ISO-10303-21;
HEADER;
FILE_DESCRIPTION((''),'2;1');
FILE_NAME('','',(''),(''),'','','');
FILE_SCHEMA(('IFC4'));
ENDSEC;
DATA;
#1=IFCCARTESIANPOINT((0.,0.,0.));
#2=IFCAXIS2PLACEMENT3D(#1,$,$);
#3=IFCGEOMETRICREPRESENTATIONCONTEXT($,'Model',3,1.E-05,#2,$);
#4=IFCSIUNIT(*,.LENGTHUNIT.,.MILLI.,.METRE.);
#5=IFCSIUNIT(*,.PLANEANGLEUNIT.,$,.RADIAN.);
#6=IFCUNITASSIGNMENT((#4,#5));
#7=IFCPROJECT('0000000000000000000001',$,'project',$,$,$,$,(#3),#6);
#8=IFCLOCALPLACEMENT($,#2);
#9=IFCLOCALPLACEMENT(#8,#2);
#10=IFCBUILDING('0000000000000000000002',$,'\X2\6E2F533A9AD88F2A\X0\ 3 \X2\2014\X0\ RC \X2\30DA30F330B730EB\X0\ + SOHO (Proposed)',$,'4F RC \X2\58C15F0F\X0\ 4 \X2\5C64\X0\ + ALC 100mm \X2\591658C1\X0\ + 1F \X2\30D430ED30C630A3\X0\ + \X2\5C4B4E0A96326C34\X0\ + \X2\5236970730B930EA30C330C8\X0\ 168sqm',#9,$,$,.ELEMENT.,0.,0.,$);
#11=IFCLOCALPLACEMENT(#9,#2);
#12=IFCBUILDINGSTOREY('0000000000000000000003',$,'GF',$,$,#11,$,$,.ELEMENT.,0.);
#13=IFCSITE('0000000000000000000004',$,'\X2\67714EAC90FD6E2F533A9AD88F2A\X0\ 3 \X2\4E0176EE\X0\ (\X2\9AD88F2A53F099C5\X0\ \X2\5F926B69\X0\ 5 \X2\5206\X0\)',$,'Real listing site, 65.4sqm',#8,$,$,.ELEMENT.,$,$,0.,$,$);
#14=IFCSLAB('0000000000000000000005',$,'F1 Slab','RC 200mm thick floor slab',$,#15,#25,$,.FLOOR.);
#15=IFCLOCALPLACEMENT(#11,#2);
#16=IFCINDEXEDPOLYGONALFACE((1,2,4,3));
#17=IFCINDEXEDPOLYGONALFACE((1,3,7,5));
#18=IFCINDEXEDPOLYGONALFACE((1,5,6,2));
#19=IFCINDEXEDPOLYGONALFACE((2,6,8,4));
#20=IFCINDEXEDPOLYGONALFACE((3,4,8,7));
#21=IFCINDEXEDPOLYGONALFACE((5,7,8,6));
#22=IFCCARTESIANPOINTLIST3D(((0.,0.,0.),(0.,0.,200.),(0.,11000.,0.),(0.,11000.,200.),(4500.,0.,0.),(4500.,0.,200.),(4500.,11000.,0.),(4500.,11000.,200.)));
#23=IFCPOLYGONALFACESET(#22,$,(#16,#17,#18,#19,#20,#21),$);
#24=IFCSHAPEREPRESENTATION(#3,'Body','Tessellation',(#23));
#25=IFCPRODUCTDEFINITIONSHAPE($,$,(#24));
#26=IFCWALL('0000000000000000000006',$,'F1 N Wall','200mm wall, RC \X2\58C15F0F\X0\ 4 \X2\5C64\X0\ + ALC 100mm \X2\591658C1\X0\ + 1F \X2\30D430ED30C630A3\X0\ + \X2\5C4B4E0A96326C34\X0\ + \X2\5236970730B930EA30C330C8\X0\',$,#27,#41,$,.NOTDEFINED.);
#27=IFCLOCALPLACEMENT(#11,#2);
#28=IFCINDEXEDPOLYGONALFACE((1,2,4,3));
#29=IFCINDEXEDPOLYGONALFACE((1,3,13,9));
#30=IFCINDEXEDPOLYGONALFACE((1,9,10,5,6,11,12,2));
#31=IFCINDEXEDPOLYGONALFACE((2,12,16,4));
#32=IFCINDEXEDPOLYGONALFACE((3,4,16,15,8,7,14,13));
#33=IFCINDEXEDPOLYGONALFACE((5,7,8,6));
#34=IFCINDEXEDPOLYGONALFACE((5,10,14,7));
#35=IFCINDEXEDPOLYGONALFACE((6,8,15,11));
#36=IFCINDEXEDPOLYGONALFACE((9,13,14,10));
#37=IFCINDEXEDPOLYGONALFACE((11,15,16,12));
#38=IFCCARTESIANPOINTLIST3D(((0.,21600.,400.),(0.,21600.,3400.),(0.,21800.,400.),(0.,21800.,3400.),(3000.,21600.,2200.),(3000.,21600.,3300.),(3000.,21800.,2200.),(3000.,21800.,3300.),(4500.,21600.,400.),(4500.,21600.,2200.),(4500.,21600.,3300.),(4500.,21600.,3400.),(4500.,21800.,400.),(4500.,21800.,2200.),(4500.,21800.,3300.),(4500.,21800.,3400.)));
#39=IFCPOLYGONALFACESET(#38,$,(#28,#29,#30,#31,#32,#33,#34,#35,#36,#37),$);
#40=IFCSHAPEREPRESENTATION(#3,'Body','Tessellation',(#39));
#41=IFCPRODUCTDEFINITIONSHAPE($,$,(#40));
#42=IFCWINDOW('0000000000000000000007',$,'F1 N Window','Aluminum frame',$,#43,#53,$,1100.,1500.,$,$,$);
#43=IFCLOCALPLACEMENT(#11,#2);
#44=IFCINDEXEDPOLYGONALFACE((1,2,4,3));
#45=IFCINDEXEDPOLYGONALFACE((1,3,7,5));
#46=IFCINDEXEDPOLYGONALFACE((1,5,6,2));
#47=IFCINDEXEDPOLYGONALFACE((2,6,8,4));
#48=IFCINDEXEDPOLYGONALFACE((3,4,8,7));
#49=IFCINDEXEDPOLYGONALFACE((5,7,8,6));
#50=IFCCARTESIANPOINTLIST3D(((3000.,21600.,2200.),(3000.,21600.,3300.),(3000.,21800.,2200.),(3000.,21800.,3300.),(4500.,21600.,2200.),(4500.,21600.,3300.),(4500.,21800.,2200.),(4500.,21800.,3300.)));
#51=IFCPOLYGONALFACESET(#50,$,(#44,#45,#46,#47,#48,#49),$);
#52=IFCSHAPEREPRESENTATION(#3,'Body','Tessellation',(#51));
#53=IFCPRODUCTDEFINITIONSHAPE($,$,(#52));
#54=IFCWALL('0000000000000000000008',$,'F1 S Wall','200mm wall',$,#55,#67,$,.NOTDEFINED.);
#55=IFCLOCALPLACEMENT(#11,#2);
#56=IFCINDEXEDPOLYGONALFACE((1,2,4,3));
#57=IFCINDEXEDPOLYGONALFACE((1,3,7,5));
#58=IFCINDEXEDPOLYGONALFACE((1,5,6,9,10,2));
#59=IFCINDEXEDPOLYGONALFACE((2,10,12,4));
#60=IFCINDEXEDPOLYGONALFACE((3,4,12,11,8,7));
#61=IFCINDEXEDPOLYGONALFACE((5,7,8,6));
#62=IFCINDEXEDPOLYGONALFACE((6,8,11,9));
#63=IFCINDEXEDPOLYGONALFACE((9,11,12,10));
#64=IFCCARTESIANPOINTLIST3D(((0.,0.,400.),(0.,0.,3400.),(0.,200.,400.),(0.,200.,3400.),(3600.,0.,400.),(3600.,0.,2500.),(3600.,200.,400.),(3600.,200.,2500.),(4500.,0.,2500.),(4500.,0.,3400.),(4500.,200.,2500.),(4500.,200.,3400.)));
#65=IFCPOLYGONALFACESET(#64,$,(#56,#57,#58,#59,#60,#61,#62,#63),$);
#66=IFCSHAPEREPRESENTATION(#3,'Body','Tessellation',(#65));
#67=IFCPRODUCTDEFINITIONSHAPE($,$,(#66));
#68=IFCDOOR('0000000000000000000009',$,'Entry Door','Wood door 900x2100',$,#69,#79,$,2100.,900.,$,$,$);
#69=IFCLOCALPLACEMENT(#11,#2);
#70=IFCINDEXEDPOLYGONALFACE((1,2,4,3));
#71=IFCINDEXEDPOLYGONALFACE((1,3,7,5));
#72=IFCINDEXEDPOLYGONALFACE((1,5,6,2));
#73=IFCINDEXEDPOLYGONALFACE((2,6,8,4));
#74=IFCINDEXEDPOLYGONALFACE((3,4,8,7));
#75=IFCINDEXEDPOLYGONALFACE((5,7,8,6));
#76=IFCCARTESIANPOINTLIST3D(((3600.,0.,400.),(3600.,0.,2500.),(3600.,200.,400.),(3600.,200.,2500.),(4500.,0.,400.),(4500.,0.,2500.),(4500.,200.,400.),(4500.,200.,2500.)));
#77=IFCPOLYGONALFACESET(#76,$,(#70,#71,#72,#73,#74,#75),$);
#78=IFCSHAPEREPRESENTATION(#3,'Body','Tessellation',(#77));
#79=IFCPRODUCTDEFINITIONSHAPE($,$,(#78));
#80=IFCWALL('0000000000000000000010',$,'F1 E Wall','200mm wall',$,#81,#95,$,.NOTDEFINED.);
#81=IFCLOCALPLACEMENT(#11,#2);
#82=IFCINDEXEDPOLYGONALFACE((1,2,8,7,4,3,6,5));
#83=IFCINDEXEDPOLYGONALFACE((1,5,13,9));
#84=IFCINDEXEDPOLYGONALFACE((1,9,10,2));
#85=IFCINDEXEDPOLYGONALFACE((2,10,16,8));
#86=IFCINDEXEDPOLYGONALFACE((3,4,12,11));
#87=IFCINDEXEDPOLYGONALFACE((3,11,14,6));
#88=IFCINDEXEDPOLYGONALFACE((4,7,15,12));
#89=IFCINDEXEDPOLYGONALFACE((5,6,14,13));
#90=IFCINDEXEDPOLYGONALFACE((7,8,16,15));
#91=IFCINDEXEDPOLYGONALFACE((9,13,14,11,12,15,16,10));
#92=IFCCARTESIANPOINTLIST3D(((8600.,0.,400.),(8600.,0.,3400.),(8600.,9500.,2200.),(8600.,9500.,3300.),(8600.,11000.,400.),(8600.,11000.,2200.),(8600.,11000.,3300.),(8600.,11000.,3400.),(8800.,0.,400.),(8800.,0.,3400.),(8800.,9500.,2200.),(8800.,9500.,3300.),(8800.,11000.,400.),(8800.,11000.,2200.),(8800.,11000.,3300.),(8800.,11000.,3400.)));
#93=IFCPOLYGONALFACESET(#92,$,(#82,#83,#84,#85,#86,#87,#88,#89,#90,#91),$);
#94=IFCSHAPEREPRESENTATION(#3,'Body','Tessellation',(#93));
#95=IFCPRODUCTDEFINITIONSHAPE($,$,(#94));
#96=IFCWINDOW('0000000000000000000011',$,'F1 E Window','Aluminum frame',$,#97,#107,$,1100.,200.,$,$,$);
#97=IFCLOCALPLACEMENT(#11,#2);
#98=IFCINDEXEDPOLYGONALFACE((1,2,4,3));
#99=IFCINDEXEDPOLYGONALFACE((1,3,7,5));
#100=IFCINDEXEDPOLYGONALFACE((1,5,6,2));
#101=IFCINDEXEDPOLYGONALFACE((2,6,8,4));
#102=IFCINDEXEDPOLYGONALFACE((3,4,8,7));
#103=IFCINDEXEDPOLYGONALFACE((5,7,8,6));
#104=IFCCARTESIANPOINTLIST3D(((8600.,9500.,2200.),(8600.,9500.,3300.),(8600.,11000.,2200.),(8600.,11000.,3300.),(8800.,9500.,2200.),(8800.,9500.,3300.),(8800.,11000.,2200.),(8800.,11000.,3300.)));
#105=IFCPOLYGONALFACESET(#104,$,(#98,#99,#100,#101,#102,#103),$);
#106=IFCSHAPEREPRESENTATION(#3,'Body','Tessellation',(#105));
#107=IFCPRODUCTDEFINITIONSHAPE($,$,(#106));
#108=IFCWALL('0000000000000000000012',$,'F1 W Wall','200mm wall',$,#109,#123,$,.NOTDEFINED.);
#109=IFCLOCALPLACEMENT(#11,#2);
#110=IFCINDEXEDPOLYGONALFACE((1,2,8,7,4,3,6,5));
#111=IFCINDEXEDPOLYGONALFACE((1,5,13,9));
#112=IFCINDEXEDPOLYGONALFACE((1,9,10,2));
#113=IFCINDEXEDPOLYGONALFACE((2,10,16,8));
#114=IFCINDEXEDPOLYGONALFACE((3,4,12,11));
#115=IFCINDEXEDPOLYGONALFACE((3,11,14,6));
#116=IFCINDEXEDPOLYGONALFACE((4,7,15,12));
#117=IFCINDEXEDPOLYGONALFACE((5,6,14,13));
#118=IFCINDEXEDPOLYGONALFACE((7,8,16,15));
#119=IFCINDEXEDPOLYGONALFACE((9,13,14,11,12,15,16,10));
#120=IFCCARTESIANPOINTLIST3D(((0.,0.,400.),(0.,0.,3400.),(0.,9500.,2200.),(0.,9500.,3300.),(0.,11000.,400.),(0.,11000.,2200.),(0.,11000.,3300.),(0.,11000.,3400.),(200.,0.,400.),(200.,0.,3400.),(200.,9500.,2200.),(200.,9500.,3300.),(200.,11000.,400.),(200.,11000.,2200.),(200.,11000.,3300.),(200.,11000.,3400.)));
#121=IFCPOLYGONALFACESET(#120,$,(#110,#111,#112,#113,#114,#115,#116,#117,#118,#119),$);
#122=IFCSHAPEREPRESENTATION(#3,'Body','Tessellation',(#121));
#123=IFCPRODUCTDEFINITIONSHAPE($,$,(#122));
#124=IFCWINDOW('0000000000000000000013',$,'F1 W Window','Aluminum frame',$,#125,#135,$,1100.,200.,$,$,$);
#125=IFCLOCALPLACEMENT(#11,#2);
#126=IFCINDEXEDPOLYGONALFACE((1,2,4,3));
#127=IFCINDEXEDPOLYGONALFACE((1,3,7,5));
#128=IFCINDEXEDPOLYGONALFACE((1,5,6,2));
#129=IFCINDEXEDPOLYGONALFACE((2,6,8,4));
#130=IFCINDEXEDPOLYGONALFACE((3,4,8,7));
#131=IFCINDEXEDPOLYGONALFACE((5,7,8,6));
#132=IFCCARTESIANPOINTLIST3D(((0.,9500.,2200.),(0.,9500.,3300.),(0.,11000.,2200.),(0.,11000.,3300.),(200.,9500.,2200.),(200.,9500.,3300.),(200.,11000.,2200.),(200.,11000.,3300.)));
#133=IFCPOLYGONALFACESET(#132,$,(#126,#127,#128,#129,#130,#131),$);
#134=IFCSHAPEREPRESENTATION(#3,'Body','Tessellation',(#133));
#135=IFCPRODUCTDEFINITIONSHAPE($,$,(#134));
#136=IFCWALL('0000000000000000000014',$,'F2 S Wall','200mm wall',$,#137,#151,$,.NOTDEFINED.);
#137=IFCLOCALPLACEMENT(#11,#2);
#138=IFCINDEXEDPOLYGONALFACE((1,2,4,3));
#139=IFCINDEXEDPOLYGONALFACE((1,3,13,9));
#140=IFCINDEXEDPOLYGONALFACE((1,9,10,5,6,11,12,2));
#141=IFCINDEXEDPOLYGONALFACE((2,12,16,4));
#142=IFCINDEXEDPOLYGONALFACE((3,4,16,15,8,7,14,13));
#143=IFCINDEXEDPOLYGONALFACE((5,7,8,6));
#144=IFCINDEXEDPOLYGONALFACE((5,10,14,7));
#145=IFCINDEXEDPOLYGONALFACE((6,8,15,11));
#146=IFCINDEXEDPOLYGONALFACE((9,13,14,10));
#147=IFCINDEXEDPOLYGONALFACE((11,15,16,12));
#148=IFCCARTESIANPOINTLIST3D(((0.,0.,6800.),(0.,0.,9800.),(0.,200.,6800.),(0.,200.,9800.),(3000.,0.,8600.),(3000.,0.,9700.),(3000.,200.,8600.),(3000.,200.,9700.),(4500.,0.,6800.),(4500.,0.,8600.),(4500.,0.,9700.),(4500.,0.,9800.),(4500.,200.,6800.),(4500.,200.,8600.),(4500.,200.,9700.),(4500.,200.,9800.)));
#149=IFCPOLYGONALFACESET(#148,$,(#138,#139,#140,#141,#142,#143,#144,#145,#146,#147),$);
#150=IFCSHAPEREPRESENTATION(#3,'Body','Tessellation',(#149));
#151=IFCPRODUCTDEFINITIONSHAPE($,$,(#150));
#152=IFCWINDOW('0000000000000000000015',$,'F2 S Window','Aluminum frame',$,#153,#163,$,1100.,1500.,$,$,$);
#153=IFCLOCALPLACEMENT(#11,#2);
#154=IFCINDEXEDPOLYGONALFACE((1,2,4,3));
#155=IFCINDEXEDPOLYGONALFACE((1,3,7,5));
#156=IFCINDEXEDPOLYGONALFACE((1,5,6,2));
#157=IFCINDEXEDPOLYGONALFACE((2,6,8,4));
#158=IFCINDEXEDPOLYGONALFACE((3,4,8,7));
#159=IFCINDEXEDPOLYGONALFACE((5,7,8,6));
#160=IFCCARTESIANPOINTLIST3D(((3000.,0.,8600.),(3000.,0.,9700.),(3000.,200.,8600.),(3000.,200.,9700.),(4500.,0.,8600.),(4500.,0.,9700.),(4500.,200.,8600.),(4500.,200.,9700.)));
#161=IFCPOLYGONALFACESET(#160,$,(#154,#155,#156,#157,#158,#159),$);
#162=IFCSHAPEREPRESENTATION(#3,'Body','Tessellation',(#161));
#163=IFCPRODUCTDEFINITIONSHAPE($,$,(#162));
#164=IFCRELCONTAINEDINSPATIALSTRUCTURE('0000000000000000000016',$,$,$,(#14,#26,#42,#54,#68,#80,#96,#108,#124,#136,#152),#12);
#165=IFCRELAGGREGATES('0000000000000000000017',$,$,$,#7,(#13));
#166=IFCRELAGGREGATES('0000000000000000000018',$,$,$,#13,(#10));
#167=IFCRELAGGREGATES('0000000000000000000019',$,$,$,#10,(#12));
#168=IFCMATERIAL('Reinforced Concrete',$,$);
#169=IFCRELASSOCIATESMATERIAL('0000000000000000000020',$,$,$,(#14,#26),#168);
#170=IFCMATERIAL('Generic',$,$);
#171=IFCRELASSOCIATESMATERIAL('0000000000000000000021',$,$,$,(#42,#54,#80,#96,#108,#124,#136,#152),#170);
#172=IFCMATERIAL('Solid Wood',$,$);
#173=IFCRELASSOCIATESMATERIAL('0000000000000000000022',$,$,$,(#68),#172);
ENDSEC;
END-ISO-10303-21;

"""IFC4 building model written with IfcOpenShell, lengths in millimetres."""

from ifc_helpers import new_model, si_unit, frame, frame_2d, origin, place, context, project, spatial, rectangle, extrude, material, element, fill, save


model = new_model("IFC4")

# Units and contexts
model_context = context("Model", 3, precision=1e-05, world=origin())
ifc_project = project(units=[si_unit("LENGTHUNIT", "METRE", prefix="MILLI"), si_unit("PLANEANGLEUNIT", "RADIAN")], contexts=[model_context])

# Site, building, storey
site_placement = place(None, origin())
site = spatial("IfcSite", under=ifc_project, at=site_placement, Name="東京都港区高輪 3 丁目 (高輪台駅 徒歩 5 分)", ObjectType="Real listing site, 65.4sqm", CompositionType="ELEMENT", RefElevation=0.0)
building_placement = place(site_placement, origin())
building = spatial("IfcBuilding", under=site, at=building_placement, Name="港区高輪 3 — RC ペンシル + SOHO (Proposed)", ObjectType="4F RC 壁式 4 層 + ALC 100mm 外壁 + 1F ピロティ + 屋上防水 + 制震スリット 168sqm", CompositionType="ELEMENT", ElevationOfRefHeight=0.0, ElevationOfTerrain=0.0)
storey_placement = place(building_placement, origin())
storey = spatial("IfcBuildingStorey", under=building, at=storey_placement, Name="GF", CompositionType="ELEMENT", Elevation=0.0)

# Slab
ifc_material_1 = material(Name="Reinforced Concrete")
slab_1_placement = place(storey_placement, origin())
element("IfcSlab", 1, at=slab_1_placement, inside=storey, material=ifc_material_1, Name="F1 Slab", Description="RC 200mm thick floor slab", PredefinedType="FLOOR", context=model_context, shape_type="SweptSolid", body=[
    extrude(rectangle(XDim=4500.0, YDim=11000.0, at=frame_2d((2250.0, 5500.0))), origin(), (0.0, 0.0, 1.0), 200.0),
])

# Wall, opening, window
wall_1_placement = place(storey_placement, frame((0.0, 10800.0, 200.0)))
wall_1 = element("IfcWall", 2, at=wall_1_placement, inside=storey, material=ifc_material_1, Name="F1 N Wall", Description="200mm wall, RC 壁式 4 層 + ALC 100mm 外壁 + 1F ピロティ + 屋上防水 + 制震スリット", PredefinedType="NOTDEFINED", context=model_context, shape_type="SweptSolid", body=[
    extrude(rectangle(XDim=4500.0, YDim=200.0, at=frame_2d((2250.0, 100.0))), frame((0.0, 10800.0, 200.0)), (0.0, 0.0, 1.0), 3000.0),
])
opening_1_placement = place(storey_placement, frame((1500.0, 10800.0, 1100.0)))
opening_1 = element("IfcOpeningElement", 3, at=opening_1_placement, cuts=wall_1, PredefinedType="NOTDEFINED", context=model_context, shape_type="SweptSolid", body=[
    extrude(rectangle(XDim=1500.0, YDim=200.0, at=frame_2d((750.0, 100.0))), frame((1500.0, 10800.0, 1100.0)), (0.0, 0.0, 1.0), 1100.0),
])
ifc_material_2 = material(Name="Generic")
window_1_placement = place(storey_placement, frame((1500.0, 10800.0, 1100.0)))
window_1 = element("IfcWindow", 4, at=window_1_placement, inside=storey, material=ifc_material_2, Name="F1 N Window", Description="Aluminum frame", OverallHeight=1100.0, OverallWidth=1500.0, context=model_context, shape_type="SweptSolid", body=[
    extrude(rectangle(XDim=1500.0, YDim=200.0, at=frame_2d((750.0, 100.0))), frame((1500.0, 10800.0, 1100.0)), (0.0, 0.0, 1.0), 1100.0),
])
fill(opening_1, window_1)

# Wall, opening, door
wall_2_placement = place(storey_placement, frame((0.0, 0.0, 200.0)))
wall_2 = element("IfcWall", 5, at=wall_2_placement, inside=storey, material=ifc_material_2, Name="F1 S Wall", Description="200mm wall", PredefinedType="NOTDEFINED", context=model_context, shape_type="SweptSolid", body=[
    extrude(rectangle(XDim=4500.0, YDim=200.0, at=frame_2d((2250.0, 100.0))), frame((0.0, 0.0, 200.0)), (0.0, 0.0, 1.0), 3000.0),
])
opening_2_placement = place(storey_placement, frame((1800.0, 0.0, 200.0)))
opening_2 = element("IfcOpeningElement", 6, at=opening_2_placement, cuts=wall_2, PredefinedType="NOTDEFINED", context=model_context, shape_type="SweptSolid", body=[
    extrude(rectangle(XDim=900.0, YDim=200.0, at=frame_2d((450.0, 100.0))), frame((1800.0, 0.0, 200.0)), (0.0, 0.0, 1.0), 2100.0),
])
ifc_material_3 = material(Name="Solid Wood")
door_placement = place(storey_placement, frame((1800.0, 0.0, 200.0)))
door = element("IfcDoor", 7, at=door_placement, inside=storey, material=ifc_material_3, Name="Entry Door", Description="Wood door 900x2100", OverallHeight=2100.0, OverallWidth=900.0, context=model_context, shape_type="SweptSolid", body=[
    extrude(rectangle(XDim=900.0, YDim=200.0, at=frame_2d((450.0, 100.0))), frame((1800.0, 0.0, 200.0)), (0.0, 0.0, 1.0), 2100.0),
])
fill(opening_2, door)

# Walls, openings, windows
wall_3_placement = place(storey_placement, frame((4300.0, 0.0, 200.0)))
wall_3 = element("IfcWall", 8, at=wall_3_placement, inside=storey, material=ifc_material_2, Name="F1 E Wall", Description="200mm wall", PredefinedType="NOTDEFINED", context=model_context, shape_type="SweptSolid", body=[
    extrude(rectangle(XDim=200.0, YDim=11000.0, at=frame_2d((100.0, 5500.0))), frame((4300.0, 0.0, 200.0)), (0.0, 0.0, 1.0), 3000.0),
])
opening_3_placement = place(storey_placement, frame((4300.0, 4750.0, 1100.0)))
opening_3 = element("IfcOpeningElement", 9, at=opening_3_placement, cuts=wall_3, PredefinedType="NOTDEFINED", context=model_context, shape_type="SweptSolid", body=[
    extrude(rectangle(XDim=200.0, YDim=1500.0, at=frame_2d((100.0, 750.0))), frame((4300.0, 4750.0, 1100.0)), (0.0, 0.0, 1.0), 1100.0),
])
window_2_placement = place(storey_placement, frame((4300.0, 4750.0, 1100.0)))
window_2 = element("IfcWindow", 10, at=window_2_placement, inside=storey, material=ifc_material_2, Name="F1 E Window", Description="Aluminum frame", OverallHeight=1100.0, OverallWidth=200.0, context=model_context, shape_type="SweptSolid", body=[
    extrude(rectangle(XDim=200.0, YDim=1500.0, at=frame_2d((100.0, 750.0))), frame((4300.0, 4750.0, 1100.0)), (0.0, 0.0, 1.0), 1100.0),
])
fill(opening_3, window_2)
wall_4_placement = place(storey_placement, frame((0.0, 0.0, 200.0)))
wall_4 = element("IfcWall", 11, at=wall_4_placement, inside=storey, material=ifc_material_2, Name="F1 W Wall", Description="200mm wall", PredefinedType="NOTDEFINED", context=model_context, shape_type="SweptSolid", body=[
    extrude(rectangle(XDim=200.0, YDim=11000.0, at=frame_2d((100.0, 5500.0))), frame((0.0, 0.0, 200.0)), (0.0, 0.0, 1.0), 3000.0),
])
opening_4_placement = place(storey_placement, frame((0.0, 4750.0, 1100.0)))
opening_4 = element("IfcOpeningElement", 12, at=opening_4_placement, cuts=wall_4, PredefinedType="NOTDEFINED", context=model_context, shape_type="SweptSolid", body=[
    extrude(rectangle(XDim=200.0, YDim=1500.0, at=frame_2d((100.0, 750.0))), frame((0.0, 4750.0, 1100.0)), (0.0, 0.0, 1.0), 1100.0),
])
window_3_placement = place(storey_placement, frame((0.0, 4750.0, 1100.0)))
window_3 = element("IfcWindow", 13, at=window_3_placement, inside=storey, material=ifc_material_2, Name="F1 W Window", Description="Aluminum frame", OverallHeight=1100.0, OverallWidth=200.0, context=model_context, shape_type="SweptSolid", body=[
    extrude(rectangle(XDim=200.0, YDim=1500.0, at=frame_2d((100.0, 750.0))), frame((0.0, 4750.0, 1100.0)), (0.0, 0.0, 1.0), 1100.0),
])
fill(opening_4, window_3)
wall_5_placement = place(storey_placement, frame((0.0, 0.0, 3400.0)))
wall_5 = element("IfcWall", 14, at=wall_5_placement, inside=storey, material=ifc_material_2, Name="F2 S Wall", Description="200mm wall", PredefinedType="NOTDEFINED", context=model_context, shape_type="SweptSolid", body=[
    extrude(rectangle(XDim=4500.0, YDim=200.0, at=frame_2d((2250.0, 100.0))), frame((0.0, 0.0, 3400.0)), (0.0, 0.0, 1.0), 3000.0),
])
opening_5_placement = place(storey_placement, frame((1500.0, 0.0, 4300.0)))
opening_5 = element("IfcOpeningElement", 15, at=opening_5_placement, cuts=wall_5, PredefinedType="NOTDEFINED", context=model_context, shape_type="SweptSolid", body=[
    extrude(rectangle(XDim=1500.0, YDim=200.0, at=frame_2d((750.0, 100.0))), frame((1500.0, 0.0, 4300.0)), (0.0, 0.0, 1.0), 1100.0),
])
window_4_placement = place(storey_placement, frame((1500.0, 0.0, 4300.0)))
window_4 = element("IfcWindow", 16, at=window_4_placement, inside=storey, material=ifc_material_2, Name="F2 S Window", Description="Aluminum frame", OverallHeight=1100.0, OverallWidth=1500.0, context=model_context, shape_type="SweptSolid", body=[
    extrude(rectangle(XDim=1500.0, YDim=200.0, at=frame_2d((750.0, 100.0))), frame((1500.0, 0.0, 4300.0)), (0.0, 0.0, 1.0), 1100.0),
])
fill(opening_5, window_4)

save(model, "model.ifc")
